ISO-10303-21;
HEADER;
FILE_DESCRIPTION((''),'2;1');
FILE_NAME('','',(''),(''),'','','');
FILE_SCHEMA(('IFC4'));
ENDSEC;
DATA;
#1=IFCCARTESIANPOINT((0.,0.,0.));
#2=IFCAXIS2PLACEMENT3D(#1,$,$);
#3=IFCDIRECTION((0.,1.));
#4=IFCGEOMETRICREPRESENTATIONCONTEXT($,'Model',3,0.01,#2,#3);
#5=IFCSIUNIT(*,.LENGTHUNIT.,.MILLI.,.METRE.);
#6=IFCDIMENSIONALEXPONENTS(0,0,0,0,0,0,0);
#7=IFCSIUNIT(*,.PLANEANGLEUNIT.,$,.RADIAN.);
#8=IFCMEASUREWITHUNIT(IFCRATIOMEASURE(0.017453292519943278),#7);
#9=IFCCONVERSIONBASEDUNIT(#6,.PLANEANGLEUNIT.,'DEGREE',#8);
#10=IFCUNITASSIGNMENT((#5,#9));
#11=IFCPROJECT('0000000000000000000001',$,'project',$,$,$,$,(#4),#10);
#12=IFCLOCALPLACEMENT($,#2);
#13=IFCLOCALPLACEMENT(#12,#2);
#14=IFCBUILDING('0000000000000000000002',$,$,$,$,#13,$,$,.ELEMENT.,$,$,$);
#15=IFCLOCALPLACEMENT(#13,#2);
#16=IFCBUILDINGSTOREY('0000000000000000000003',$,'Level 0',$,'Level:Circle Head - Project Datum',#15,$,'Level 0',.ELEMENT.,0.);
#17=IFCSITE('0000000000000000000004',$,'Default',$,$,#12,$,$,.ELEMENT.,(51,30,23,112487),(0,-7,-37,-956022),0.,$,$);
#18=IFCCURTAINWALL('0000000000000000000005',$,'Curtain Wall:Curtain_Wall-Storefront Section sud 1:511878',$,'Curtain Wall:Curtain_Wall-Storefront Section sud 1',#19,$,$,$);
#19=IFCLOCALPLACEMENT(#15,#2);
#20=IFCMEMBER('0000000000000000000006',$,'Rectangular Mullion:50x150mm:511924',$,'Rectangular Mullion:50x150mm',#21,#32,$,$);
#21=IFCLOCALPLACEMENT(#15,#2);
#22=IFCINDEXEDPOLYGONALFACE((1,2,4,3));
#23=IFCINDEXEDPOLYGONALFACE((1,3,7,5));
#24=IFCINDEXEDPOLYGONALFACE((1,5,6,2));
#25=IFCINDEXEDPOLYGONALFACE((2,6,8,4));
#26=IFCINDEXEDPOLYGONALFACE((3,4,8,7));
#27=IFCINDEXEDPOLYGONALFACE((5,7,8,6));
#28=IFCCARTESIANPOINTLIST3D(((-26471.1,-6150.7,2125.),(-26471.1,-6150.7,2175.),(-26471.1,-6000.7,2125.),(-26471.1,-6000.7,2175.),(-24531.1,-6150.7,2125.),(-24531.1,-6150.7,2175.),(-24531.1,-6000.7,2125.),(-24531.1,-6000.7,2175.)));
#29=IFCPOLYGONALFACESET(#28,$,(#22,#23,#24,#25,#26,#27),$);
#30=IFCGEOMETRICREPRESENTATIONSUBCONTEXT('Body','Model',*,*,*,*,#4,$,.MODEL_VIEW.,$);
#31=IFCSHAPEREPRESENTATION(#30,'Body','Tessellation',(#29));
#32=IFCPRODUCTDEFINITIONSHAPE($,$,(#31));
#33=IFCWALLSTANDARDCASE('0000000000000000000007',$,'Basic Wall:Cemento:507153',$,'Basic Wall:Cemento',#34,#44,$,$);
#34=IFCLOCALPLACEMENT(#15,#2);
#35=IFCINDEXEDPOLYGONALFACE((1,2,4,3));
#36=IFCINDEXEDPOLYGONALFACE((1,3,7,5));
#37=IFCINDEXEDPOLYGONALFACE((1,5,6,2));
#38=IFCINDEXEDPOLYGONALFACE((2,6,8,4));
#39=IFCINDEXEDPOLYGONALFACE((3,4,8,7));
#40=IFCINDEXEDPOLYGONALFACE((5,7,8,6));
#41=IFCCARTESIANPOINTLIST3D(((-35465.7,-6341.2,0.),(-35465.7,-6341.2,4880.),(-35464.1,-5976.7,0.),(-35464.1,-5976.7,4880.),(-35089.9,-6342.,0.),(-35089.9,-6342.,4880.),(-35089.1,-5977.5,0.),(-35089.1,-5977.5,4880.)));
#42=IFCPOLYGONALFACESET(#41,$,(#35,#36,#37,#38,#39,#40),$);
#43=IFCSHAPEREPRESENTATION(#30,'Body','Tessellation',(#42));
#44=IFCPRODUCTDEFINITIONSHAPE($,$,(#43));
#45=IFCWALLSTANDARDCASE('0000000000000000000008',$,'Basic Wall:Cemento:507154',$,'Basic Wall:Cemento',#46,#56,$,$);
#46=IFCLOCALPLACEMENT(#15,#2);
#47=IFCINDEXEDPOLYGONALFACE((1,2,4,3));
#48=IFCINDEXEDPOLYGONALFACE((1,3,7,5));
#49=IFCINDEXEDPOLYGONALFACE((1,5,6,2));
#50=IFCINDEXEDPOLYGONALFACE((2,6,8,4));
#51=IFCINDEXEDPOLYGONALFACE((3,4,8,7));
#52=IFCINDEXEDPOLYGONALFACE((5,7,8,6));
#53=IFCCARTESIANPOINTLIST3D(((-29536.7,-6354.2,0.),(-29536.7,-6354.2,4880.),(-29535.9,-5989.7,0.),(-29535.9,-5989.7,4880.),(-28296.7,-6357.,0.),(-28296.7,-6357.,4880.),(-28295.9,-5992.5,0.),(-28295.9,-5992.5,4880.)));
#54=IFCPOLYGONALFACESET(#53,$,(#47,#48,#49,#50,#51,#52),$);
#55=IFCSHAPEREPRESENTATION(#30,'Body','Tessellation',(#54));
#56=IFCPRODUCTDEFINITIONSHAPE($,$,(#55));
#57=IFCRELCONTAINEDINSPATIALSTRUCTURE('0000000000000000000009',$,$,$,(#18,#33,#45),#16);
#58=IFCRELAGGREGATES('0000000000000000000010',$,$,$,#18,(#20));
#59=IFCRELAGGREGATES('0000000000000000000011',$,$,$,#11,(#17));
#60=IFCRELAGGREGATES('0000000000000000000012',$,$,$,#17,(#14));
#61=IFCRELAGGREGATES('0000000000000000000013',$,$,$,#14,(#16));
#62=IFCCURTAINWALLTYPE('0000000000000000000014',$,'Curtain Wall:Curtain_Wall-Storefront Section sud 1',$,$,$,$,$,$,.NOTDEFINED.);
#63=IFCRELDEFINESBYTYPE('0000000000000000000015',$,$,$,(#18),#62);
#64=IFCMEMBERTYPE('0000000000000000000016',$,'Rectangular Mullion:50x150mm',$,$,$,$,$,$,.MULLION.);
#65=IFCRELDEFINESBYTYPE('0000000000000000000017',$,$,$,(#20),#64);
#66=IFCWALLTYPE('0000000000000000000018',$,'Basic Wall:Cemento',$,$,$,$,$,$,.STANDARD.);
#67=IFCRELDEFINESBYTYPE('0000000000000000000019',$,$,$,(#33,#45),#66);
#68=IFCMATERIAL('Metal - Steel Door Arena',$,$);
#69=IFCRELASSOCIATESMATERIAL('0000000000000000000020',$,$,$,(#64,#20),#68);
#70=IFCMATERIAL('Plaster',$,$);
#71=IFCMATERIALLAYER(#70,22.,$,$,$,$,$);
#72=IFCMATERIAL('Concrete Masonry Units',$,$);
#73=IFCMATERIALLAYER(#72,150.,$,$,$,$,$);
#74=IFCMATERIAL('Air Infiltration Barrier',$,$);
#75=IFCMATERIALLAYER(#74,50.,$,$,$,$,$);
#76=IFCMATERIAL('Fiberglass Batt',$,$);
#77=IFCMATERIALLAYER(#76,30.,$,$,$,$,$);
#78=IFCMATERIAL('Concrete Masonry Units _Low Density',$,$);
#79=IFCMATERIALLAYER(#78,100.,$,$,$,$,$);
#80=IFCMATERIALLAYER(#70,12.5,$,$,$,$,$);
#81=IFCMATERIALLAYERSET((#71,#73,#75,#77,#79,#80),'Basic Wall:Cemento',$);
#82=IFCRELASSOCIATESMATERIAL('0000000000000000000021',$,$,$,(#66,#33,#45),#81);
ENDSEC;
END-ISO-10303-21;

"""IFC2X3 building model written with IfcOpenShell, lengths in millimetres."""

from ifc_helpers import new_model, entity, si_unit, converted_unit, direction, frame, frame_2d, origin, origin_2d_with_axis, place, context, subcontext, project, spatial, polyline, rectangle, outline, extrude, source, transform, mapped, material, layer, layer_set, layer_usage, type_object, type_shapes, element, aggregate, save


model = new_model("IFC2X3")

# Units and contexts
model_context = context("Model", 3, precision=0.01, world=origin(), true_north=direction((0.0, 1.0)))
body_context = subcontext(model_context, "Body", "Model", "MODEL_VIEW")
ifc_project = project(units=[si_unit("LENGTHUNIT", "METRE", prefix="MILLI"), converted_unit("PLANEANGLEUNIT", "DEGREE", entity("IfcRatioMeasure", 0.017453292519943278), si_unit("PLANEANGLEUNIT", "RADIAN"), dimensions=[0, 0, 0, 0, 0, 0, 0])], contexts=[model_context])

# Site, building, storey
site_placement = place(None, origin())
site = spatial("IfcSite", under=ifc_project, at=site_placement, Name="Default", CompositionType="ELEMENT", RefLatitude=(51, 30, 23, 112487), RefLongitude=(0, -7, -37, -956022), RefElevation=0.0)
building_placement = place(site_placement, origin())
building = spatial("IfcBuilding", under=site, at=building_placement, CompositionType="ELEMENT")
storey_placement = place(building_placement, origin())
storey = spatial("IfcBuildingStorey", under=building, at=storey_placement, Name="Level 0", ObjectType="Level:Circle Head - Project Datum", LongName="Level 0", CompositionType="ELEMENT", Elevation=0.0)

# Shared definitions
curtain_wall_type = type_object("IfcCurtainWallType", Name="Curtain Wall:Curtain_Wall-Storefront Section sud 1", PredefinedType="NOTDEFINED")
ifc_material_1 = material(Name="Metal - Steel Door Arena")

# Curtain wall, member
curtain_wall_1_placement = place(storey_placement, origin())
curtain_wall_1 = element("IfcCurtainWall", 1, at=curtain_wall_1_placement, inside=storey, type_object=curtain_wall_type, Name="Curtain Wall:Curtain_Wall-Storefront Section sud 1:511878", ObjectType="Curtain Wall:Curtain_Wall-Storefront Section sud 1")
member_type_1 = type_object("IfcMemberType", Name="Rectangular Mullion:50x150mm", PredefinedType="MULLION", material=ifc_material_1)
shared_shape_1 = source(origin(), body_context, "Body", "SweptSolid", [
    extrude(rectangle(XDim=150.0, YDim=50.0, at=origin_2d_with_axis()), frame((0.0, 0.0, -1940.0), z_axis=(0.0, 0.0, 1.0), x_axis=(0.0, -1.0, 0.0)), (0.0, 0.0, 1.0), 1940.0),
])
type_shapes(member_type_1, [shared_shape_1])
member_1_placement = place(curtain_wall_1_placement, frame((-24531.1, -6075.7, 2150.0), z_axis=(1.0, 0.0, 0.0), x_axis=(0.0, 0.0, 1.0)))
member_1 = element("IfcMember", 2, at=member_1_placement, type_object=member_type_1, material=ifc_material_1, Name="Rectangular Mullion:50x150mm:511924", ObjectType="Rectangular Mullion:50x150mm", context=body_context, shape_type="MappedRepresentation", body=[
    mapped(shared_shape_1, transform((0.0, 0.0, 0.0), scale=1.0)),
])
aggregate(curtain_wall_1, [member_1])

# Walls
ifc_material_2 = material(Name="Plaster")
ifc_layer_1 = layer(ifc_material_2, 22.0)
ifc_material_3 = material(Name="Concrete Masonry Units")
ifc_layer_2 = layer(ifc_material_3, 150.0)
ifc_material_4 = material(Name="Air Infiltration Barrier")
ifc_layer_3 = layer(ifc_material_4, 50.0)
ifc_material_5 = material(Name="Fiberglass Batt")
ifc_layer_4 = layer(ifc_material_5, 30.0)
ifc_material_6 = material(Name="Concrete Masonry Units _Low Density")
ifc_layer_5 = layer(ifc_material_6, 100.0)
ifc_layer_6 = layer(ifc_material_2, 12.5)
ifc_layer_set = layer_set([ifc_layer_1, ifc_layer_2, ifc_layer_3, ifc_layer_4, ifc_layer_5, ifc_layer_6], Name="Basic Wall:Cemento")
ifc_layer_usage_1 = layer_usage(ifc_layer_set, "AXIS2", "NEGATIVE", 182.3)
wall_type = type_object("IfcWallType", Name="Basic Wall:Cemento", PredefinedType="STANDARD", material=ifc_layer_set)
wall_1_placement = place(storey_placement, frame((-35089.5, -6159.8, 0.0), z_axis=(0.0, 0.0, 1.0), x_axis=(-0.999998, 0.002199, 0.0)))
element("IfcWallStandardCase", 3, at=wall_1_placement, inside=storey, type_object=wall_type, material=ifc_layer_usage_1, Name="Basic Wall:Cemento:507153", ObjectType="Basic Wall:Cemento", context=body_context, shape_type="SweptSolid", body=[
    extrude(outline(polyline([(374.9, -182.2), (375.8, 182.3), (0.0, 182.3), (0.0, -182.2), (374.9, -182.2)])), origin(), (0.0, 0.0, 1.0), 4880.0),
])
ifc_layer_usage_2 = layer_usage(ifc_layer_set, "AXIS2", "NEGATIVE", 182.3)
wall_2_placement = place(storey_placement, frame((-28296.3, -6174.7, 0.0), z_axis=(0.0, 0.0, 1.0), x_axis=(-0.999998, 0.002199, 0.0)))
element("IfcWallStandardCase", 4, at=wall_2_placement, inside=storey, type_object=wall_type, material=ifc_layer_usage_2, Name="Basic Wall:Cemento:507154", ObjectType="Basic Wall:Cemento", context=body_context, shape_type="SweptSolid", body=[
    extrude(rectangle(XDim=1240.0, YDim=364.5, at=frame_2d((620.0, 0.0), x_axis=(-1.0, 0.0))), origin(), (0.0, 0.0, 1.0), 4880.0),
])

save(model, "model.ifc")
